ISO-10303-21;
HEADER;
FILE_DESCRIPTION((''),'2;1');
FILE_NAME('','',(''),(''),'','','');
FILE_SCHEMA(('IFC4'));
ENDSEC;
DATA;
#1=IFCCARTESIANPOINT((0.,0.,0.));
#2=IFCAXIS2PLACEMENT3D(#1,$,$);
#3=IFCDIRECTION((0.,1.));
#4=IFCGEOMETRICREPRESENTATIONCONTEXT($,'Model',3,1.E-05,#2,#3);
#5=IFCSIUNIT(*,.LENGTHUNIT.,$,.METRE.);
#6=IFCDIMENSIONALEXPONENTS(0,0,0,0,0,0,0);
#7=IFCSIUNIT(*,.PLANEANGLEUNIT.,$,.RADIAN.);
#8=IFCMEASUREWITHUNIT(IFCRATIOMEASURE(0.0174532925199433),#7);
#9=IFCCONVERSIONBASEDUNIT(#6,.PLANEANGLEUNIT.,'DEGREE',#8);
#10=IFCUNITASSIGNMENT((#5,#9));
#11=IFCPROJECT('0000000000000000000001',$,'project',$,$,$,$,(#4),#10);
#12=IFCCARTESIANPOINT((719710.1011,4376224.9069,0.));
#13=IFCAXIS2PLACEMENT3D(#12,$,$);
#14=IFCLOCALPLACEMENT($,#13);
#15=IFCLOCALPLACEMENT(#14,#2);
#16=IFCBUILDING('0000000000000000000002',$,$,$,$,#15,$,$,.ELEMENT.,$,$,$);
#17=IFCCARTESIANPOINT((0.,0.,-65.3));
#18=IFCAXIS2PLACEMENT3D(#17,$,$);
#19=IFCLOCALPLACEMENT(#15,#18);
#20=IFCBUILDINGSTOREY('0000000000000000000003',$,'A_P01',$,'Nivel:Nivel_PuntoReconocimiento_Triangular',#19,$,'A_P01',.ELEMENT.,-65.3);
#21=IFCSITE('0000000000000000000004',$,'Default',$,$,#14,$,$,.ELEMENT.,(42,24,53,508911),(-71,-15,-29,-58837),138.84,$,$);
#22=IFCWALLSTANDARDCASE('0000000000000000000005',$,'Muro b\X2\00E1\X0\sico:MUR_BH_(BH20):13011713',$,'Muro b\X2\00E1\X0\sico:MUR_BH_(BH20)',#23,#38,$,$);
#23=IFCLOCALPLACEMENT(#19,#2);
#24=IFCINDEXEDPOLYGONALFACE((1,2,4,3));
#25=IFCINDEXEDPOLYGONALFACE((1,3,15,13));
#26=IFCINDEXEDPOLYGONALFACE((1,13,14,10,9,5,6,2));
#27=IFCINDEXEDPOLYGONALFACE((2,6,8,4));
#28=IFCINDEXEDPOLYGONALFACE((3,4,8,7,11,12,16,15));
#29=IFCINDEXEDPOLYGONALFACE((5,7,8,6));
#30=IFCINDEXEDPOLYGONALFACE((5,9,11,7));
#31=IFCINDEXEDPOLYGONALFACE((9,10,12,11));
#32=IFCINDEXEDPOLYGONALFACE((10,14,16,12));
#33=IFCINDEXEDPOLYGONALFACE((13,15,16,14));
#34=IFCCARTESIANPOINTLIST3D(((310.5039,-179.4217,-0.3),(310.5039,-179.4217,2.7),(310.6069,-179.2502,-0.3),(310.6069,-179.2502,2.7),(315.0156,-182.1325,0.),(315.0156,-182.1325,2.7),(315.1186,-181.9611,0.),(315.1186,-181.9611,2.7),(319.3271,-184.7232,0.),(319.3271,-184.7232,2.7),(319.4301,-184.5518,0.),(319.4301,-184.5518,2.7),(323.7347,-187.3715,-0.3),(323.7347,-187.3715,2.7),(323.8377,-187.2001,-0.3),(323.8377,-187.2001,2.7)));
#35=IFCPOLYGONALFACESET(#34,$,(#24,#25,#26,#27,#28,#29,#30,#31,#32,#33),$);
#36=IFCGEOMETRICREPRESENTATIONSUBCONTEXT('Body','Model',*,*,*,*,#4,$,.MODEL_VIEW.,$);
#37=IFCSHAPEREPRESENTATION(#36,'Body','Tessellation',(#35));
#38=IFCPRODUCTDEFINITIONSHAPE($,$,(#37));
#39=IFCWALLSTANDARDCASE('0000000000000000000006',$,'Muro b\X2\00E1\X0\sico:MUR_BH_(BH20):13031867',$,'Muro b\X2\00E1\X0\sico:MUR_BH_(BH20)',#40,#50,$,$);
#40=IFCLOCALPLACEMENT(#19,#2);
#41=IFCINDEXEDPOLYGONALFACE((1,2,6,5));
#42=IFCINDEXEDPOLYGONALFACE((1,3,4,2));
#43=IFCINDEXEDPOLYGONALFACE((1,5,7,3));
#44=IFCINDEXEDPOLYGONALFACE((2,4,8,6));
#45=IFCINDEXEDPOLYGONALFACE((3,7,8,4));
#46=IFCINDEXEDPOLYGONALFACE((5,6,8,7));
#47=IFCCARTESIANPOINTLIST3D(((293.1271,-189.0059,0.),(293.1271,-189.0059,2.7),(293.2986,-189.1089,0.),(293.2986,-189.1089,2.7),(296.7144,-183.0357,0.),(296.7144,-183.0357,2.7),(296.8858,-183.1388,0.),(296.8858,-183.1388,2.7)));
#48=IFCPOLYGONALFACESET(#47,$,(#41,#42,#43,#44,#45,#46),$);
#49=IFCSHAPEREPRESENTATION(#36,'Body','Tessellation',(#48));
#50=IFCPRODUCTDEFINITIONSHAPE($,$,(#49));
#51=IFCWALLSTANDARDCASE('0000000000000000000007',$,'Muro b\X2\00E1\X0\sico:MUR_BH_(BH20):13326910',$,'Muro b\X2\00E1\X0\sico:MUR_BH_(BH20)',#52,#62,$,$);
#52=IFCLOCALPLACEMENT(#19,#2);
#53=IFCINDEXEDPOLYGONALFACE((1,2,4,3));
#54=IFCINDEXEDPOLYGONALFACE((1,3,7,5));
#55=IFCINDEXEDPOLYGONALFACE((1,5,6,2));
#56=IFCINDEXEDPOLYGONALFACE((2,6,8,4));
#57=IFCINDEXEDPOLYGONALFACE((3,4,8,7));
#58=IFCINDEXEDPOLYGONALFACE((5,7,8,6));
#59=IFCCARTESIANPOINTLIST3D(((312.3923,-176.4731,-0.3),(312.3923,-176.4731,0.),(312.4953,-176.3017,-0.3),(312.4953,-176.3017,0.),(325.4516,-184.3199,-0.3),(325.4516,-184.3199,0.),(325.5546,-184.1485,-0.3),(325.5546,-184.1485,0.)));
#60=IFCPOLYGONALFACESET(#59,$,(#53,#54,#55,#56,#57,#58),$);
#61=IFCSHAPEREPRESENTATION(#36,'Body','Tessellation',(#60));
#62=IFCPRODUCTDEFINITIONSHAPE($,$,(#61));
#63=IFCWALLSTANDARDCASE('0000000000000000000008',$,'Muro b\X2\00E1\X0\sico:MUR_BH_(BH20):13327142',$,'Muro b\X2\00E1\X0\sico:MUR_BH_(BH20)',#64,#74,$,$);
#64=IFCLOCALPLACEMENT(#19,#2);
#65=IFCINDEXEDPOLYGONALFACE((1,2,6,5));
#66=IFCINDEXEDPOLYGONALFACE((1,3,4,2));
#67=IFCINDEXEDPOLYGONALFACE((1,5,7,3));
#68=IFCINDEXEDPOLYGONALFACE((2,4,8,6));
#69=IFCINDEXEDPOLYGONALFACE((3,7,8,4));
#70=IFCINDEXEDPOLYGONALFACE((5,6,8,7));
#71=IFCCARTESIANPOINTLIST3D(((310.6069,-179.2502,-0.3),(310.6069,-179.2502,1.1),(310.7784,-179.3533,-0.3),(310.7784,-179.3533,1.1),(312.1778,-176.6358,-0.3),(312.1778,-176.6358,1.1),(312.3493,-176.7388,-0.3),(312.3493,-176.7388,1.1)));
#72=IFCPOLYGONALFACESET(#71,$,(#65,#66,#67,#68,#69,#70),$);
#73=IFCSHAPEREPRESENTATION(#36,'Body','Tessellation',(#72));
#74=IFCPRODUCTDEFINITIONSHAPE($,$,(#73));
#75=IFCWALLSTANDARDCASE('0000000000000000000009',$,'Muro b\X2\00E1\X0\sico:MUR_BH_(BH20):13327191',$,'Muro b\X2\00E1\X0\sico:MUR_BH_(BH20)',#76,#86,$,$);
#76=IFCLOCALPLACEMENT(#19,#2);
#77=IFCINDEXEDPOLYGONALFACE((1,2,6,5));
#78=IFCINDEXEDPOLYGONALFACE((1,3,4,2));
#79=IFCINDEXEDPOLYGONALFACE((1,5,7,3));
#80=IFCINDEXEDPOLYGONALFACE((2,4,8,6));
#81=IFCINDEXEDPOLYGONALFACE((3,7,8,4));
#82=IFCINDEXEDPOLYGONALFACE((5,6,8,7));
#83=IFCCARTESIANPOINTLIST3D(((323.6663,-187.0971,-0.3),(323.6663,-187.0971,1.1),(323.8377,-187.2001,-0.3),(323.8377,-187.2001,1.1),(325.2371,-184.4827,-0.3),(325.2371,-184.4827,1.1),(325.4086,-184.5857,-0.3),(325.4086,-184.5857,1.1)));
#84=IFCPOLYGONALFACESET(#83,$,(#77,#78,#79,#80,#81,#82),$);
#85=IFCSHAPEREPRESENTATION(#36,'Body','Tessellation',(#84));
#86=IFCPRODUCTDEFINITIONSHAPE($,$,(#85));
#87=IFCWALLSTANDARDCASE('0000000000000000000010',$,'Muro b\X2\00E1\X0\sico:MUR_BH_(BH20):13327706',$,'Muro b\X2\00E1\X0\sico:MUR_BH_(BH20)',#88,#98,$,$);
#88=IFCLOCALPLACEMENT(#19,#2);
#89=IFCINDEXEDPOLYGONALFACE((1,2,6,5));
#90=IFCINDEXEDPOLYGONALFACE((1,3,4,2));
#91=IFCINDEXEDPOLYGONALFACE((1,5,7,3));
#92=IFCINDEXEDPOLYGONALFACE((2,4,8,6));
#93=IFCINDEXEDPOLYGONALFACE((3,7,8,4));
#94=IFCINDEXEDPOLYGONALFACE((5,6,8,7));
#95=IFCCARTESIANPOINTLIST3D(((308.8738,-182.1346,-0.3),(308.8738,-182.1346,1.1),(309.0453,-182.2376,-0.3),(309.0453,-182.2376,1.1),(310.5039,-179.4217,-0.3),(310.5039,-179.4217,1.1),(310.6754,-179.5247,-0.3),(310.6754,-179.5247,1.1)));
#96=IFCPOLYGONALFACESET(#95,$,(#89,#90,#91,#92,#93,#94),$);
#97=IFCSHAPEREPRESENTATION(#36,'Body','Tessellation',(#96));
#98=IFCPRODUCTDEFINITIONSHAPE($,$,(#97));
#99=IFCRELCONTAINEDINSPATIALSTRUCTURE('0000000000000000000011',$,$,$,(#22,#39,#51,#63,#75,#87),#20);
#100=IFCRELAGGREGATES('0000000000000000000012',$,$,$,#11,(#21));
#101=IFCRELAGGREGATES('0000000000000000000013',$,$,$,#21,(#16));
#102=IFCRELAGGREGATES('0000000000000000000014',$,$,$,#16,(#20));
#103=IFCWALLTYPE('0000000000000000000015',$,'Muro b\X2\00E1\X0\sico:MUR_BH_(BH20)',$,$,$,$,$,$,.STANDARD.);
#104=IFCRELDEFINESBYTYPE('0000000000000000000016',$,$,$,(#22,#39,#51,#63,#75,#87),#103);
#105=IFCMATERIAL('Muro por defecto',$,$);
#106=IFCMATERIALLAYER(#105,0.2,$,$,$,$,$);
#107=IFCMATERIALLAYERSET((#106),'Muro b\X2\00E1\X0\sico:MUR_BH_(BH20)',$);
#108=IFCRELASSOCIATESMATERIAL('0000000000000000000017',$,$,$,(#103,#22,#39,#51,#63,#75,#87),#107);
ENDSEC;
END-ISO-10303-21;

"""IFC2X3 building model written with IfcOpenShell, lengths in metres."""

from ifc_helpers import new_model, entity, si_unit, converted_unit, direction, frame, frame_2d, origin, place, context, subcontext, project, spatial, rectangle, extrude, material, layer, layer_set, layer_usage, type_object, element, save


model = new_model("IFC2X3")

# Units and contexts
model_context = context("Model", 3, precision=1e-05, world=origin(), true_north=direction((0.0, 1.0)))
body_context = subcontext(model_context, "Body", "Model", "MODEL_VIEW")
ifc_project = project(units=[si_unit("LENGTHUNIT", "METRE"), converted_unit("PLANEANGLEUNIT", "DEGREE", entity("IfcRatioMeasure", 0.0174532925199433), si_unit("PLANEANGLEUNIT", "RADIAN"), dimensions=[0, 0, 0, 0, 0, 0, 0])], contexts=[model_context])

# Site, building, storey
site_placement = place(None, frame((719710.1011, 4376224.9069, 0.0)))
site = spatial("IfcSite", under=ifc_project, at=site_placement, Name="Default", CompositionType="ELEMENT", RefLatitude=(42, 24, 53, 508911), RefLongitude=(-71, -15, -29, -58837), RefElevation=138.84)
building_placement = place(site_placement, origin())
building = spatial("IfcBuilding", under=site, at=building_placement, CompositionType="ELEMENT")
storey_placement = place(building_placement, frame((0.0, 0.0, -65.3)))
storey = spatial("IfcBuildingStorey", under=building, at=storey_placement, Name="A_P01", ObjectType="Nivel:Nivel_PuntoReconocimiento_Triangular", LongName="A_P01", CompositionType="ELEMENT", Elevation=-65.3)

# Shared definitions
ifc_material_1 = material(Name="Muro por defecto")
ifc_layer = layer(ifc_material_1, 0.2)
ifc_layer_set = layer_set([ifc_layer], Name="Muro básico:MUR_BH_(BH20)")
wall_type = type_object("IfcWallType", Name="Muro básico:MUR_BH_(BH20)", PredefinedType="STANDARD", material=ifc_layer_set)

# Wall, opening
ifc_layer_usage_1 = layer_usage(ifc_layer_set, "AXIS2", "NEGATIVE", 0.1)
wall_1_placement = place(storey_placement, frame((310.5554, -179.336, -0.3), z_axis=(0.0, 0.0, 1.0), x_axis=(0.857167, -0.515038, 0.0)))
wall_1 = element("IfcWallStandardCase", 1, at=wall_1_placement, inside=storey, type_object=wall_type, material=ifc_layer_usage_1, Name="Muro básico:MUR_BH_(BH20):13011713", ObjectType="Muro básico:MUR_BH_(BH20)", context=body_context, shape_type="SweptSolid", body=[
    extrude(rectangle(XDim=15.4354, YDim=0.2, at=frame_2d((7.7177, 0.0), x_axis=(-1.0, 0.0))), origin(), (0.0, 0.0, 1.0), 3.0),
])
opening_1_placement = place(wall_1_placement, origin())
element("IfcOpeningElement", 2, at=opening_1_placement, cuts=wall_1, ObjectType="Opening", context=body_context, shape_type="SweptSolid", body=[
    extrude(rectangle(XDim=2.7, YDim=5.03, at=frame_2d((0.0, 0.0), x_axis=(1.0, 0.0))), frame((7.7784, -0.2524, 1.65), z_axis=(0.0, 1.0, 0.0), x_axis=(0.0, 0.0, 1.0)), (0.0, 0.0, 1.0), 0.5048),
])

# Walls
ifc_layer_usage_2 = layer_usage(ifc_layer_set, "AXIS2", "NEGATIVE", 0.1)
wall_2_placement = place(storey_placement, frame((296.8001, -183.0873, 0.0), z_axis=(0.0, 0.0, 1.0), x_axis=(-0.515038, -0.857167, 0.0)))
element("IfcWallStandardCase", 3, at=wall_2_placement, inside=storey, type_object=wall_type, material=ifc_layer_usage_2, Name="Muro básico:MUR_BH_(BH20):13031867", ObjectType="Muro básico:MUR_BH_(BH20)", context=body_context, shape_type="SweptSolid", body=[
    extrude(rectangle(XDim=6.965, YDim=0.2, at=frame_2d((3.4825, 0.0), x_axis=(-1.0, 0.0))), origin(), (0.0, 0.0, 1.0), 2.7),
])
ifc_layer_usage_3 = layer_usage(ifc_layer_set, "AXIS2", "NEGATIVE", 0.1)
wall_3_placement = place(storey_placement, frame((312.4438, -176.3874, -0.3), z_axis=(0.0, 0.0, 1.0), x_axis=(0.857167, -0.515038, 0.0)))
element("IfcWallStandardCase", 4, at=wall_3_placement, inside=storey, type_object=wall_type, material=ifc_layer_usage_3, Name="Muro básico:MUR_BH_(BH20):13326910", ObjectType="Muro básico:MUR_BH_(BH20)", context=body_context, shape_type="SweptSolid", body=[
    extrude(rectangle(XDim=15.2354, YDim=0.2, at=frame_2d((7.6177, 0.0), x_axis=(-1.0, 0.0))), origin(), (0.0, 0.0, 1.0), 0.3),
])
ifc_layer_usage_4 = layer_usage(ifc_layer_set, "AXIS2", "NEGATIVE", 0.1)
wall_4_placement = place(storey_placement, frame((310.6927, -179.3018, -0.3), z_axis=(0.0, 0.0, 1.0), x_axis=(0.515038, 0.857167, 0.0)))
element("IfcWallStandardCase", 5, at=wall_4_placement, inside=storey, type_object=wall_type, material=ifc_layer_usage_4, Name="Muro básico:MUR_BH_(BH20):13327142", ObjectType="Muro básico:MUR_BH_(BH20)", context=body_context, shape_type="SweptSolid", body=[
    extrude(rectangle(XDim=3.0501, YDim=0.2, at=frame_2d((1.525, 0.0), x_axis=(-1.0, 0.0))), origin(), (0.0, 0.0, 1.0), 1.4),
])
ifc_layer_usage_5 = layer_usage(ifc_layer_set, "AXIS2", "POSITIVE", -0.1)
wall_5_placement = place(storey_placement, frame((323.752, -187.1486, -0.3), z_axis=(0.0, 0.0, 1.0), x_axis=(0.515038, 0.857167, 0.0)))
element("IfcWallStandardCase", 6, at=wall_5_placement, inside=storey, type_object=wall_type, material=ifc_layer_usage_5, Name="Muro básico:MUR_BH_(BH20):13327191", ObjectType="Muro básico:MUR_BH_(BH20)", context=body_context, shape_type="SweptSolid", body=[
    extrude(rectangle(XDim=3.05, YDim=0.2, at=frame_2d((1.525, 0.0), x_axis=(-1.0, 0.0))), origin(), (0.0, 0.0, 1.0), 1.4),
])

# Wall, opening
ifc_layer_usage_6 = layer_usage(ifc_layer_set, "AXIS2", "NEGATIVE", 0.1)
wall_6_placement = place(storey_placement, frame((308.9596, -182.1861, -0.3), z_axis=(0.0, 0.0, 1.0), x_axis=(0.515038, 0.857167, 0.0)))
wall_6 = element("IfcWallStandardCase", 7, at=wall_6_placement, inside=storey, type_object=wall_type, material=ifc_layer_usage_6, Name="Muro básico:MUR_BH_(BH20):13327706", ObjectType="Muro básico:MUR_BH_(BH20)", context=body_context, shape_type="SweptSolid", body=[
    extrude(rectangle(XDim=3.165, YDim=0.2, at=frame_2d((1.5825, 0.0), x_axis=(-1.0, 0.0))), origin(), (0.0, 0.0, 1.0), 1.4),
])
opening_2_placement = place(wall_6_placement, origin())
element("IfcOpeningElement", 8, at=opening_2_placement, cuts=wall_6, ObjectType="Opening", context=body_context, shape_type="SweptSolid", body=[
    extrude(rectangle(XDim=1.6, YDim=3.165, at=frame_2d((0.0, 0.0), x_axis=(1.0, 0.0))), frame((1.5825, -0.2524, 2.2), z_axis=(0.0, 1.0, 0.0), x_axis=(0.0, 0.0, 1.0)), (0.0, 0.0, 1.0), 0.5048),
])

save(model, "model.ifc")
